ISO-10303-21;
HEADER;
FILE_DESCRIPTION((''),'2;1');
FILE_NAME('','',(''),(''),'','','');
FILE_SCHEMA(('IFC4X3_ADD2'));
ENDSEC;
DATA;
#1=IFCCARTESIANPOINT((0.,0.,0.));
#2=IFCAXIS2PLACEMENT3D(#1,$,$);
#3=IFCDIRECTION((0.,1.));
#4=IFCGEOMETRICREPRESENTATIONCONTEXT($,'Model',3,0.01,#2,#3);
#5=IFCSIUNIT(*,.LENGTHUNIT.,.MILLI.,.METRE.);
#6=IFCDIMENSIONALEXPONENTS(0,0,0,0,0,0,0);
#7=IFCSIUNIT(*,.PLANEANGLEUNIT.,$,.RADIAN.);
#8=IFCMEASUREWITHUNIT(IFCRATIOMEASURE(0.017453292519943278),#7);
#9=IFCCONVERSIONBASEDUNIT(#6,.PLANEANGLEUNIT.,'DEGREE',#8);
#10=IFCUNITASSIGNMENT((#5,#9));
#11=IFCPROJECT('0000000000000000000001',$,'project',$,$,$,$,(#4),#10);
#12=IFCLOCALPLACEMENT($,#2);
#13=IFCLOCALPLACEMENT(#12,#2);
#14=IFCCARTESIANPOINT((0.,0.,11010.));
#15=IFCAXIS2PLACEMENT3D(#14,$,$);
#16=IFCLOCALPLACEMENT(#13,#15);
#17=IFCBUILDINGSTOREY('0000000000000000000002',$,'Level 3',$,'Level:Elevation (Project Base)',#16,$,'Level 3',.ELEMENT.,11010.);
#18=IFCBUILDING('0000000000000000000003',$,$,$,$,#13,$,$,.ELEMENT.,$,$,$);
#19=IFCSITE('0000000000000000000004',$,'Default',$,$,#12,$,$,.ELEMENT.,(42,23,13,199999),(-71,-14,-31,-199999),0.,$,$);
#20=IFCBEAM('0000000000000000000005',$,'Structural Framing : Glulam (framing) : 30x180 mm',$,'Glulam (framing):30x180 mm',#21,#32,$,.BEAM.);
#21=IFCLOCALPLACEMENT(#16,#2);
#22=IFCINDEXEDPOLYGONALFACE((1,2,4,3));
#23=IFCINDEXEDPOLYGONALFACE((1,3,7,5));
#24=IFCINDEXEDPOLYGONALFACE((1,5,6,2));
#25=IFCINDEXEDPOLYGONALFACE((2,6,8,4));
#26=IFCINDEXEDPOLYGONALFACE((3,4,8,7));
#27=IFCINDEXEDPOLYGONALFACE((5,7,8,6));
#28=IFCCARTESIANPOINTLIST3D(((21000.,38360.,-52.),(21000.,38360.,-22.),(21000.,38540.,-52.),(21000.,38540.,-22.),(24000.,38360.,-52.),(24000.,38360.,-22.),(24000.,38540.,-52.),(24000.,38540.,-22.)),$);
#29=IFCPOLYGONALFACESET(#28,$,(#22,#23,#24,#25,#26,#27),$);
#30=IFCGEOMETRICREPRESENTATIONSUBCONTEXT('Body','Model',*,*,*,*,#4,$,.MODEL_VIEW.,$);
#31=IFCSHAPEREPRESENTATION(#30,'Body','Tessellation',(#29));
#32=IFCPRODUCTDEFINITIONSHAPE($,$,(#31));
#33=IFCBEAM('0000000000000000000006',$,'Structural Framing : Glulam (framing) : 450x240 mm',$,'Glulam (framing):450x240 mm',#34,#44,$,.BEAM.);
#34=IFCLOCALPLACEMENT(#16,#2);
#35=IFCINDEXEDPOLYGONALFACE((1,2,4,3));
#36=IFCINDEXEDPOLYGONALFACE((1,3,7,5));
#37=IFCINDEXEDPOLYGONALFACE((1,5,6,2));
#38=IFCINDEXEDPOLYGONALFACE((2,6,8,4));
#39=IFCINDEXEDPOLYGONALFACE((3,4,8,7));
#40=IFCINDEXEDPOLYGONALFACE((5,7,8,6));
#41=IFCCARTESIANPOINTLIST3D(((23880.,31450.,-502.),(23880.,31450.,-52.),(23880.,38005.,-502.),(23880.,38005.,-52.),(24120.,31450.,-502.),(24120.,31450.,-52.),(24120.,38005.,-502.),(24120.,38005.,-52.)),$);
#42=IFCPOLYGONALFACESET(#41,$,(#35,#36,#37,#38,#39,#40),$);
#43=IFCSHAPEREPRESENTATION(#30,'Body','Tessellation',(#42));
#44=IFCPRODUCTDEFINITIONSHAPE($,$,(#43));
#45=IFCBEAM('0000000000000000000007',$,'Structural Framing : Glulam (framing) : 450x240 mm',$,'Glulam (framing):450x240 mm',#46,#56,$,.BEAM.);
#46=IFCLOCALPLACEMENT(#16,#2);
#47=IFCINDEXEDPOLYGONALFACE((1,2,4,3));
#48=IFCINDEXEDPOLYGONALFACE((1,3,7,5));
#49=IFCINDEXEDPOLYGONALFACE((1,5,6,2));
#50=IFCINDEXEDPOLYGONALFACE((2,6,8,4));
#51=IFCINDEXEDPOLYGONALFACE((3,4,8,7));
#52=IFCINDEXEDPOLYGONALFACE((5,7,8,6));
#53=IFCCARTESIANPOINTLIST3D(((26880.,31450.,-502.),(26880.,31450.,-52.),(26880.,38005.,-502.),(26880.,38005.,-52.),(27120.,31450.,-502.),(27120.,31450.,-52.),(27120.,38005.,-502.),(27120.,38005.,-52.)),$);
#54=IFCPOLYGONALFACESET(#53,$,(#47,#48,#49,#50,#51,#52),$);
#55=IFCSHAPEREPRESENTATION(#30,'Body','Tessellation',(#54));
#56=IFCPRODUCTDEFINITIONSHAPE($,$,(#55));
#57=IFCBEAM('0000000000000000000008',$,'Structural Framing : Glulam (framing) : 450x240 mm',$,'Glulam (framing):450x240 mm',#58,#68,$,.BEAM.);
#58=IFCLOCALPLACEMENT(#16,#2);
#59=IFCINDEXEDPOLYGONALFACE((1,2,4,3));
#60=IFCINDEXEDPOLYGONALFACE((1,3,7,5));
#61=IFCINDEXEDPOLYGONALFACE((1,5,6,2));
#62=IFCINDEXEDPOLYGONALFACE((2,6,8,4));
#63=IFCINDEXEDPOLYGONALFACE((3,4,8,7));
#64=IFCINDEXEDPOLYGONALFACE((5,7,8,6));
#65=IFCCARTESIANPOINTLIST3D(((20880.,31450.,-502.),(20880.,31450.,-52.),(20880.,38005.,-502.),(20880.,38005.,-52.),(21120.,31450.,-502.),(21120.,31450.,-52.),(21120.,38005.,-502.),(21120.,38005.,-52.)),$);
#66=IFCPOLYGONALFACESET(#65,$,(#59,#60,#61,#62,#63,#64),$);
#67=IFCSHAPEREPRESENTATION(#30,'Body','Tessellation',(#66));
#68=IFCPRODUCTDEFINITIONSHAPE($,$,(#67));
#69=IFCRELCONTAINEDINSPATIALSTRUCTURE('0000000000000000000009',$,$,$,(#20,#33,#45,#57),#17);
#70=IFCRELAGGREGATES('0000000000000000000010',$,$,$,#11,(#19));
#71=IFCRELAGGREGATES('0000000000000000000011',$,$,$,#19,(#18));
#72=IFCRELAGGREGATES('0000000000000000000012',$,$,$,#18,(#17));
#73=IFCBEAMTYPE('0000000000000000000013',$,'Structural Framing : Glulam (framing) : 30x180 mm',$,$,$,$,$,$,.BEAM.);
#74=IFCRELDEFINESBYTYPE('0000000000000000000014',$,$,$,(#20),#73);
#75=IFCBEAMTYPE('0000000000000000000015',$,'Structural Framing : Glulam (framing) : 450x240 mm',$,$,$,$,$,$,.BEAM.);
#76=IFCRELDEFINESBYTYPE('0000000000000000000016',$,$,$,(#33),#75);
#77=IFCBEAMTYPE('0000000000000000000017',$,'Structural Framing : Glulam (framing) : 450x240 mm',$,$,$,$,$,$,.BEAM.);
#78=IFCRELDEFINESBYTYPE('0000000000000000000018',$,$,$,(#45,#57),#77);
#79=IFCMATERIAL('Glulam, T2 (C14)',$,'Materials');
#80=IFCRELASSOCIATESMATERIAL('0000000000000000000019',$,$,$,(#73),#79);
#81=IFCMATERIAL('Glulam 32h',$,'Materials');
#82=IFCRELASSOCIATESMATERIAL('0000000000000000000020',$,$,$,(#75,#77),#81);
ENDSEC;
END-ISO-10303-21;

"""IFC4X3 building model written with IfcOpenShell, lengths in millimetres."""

from ifc_helpers import new_model, entity, si_unit, converted_unit, direction, frame, origin, origin_2d_with_axis, place, context, subcontext, project, spatial, rectangle, extrude, source, transform, mapped, material, material_profile, profile_set, type_object, type_shapes, element, save


model = new_model("IFC4X3")

# Units and contexts
model_context = context("Model", 3, precision=0.01, world=origin(), true_north=direction((0.0, 1.0)))
body_context = subcontext(model_context, "Body", "Model", "MODEL_VIEW")
ifc_project = project(units=[si_unit("LENGTHUNIT", "METRE", prefix="MILLI"), converted_unit("PLANEANGLEUNIT", "DEGREE", entity("IfcRatioMeasure", 0.017453292519943278), si_unit("PLANEANGLEUNIT", "RADIAN"), dimensions=[0, 0, 0, 0, 0, 0, 0])], contexts=[model_context])

# Site, building, storey
site_placement = place(None, origin())
site = spatial("IfcSite", under=ifc_project, at=site_placement, Name="Default", CompositionType="ELEMENT", RefLatitude=(42, 23, 13, 199999), RefLongitude=(-71, -14, -31, -199999), RefElevation=0.0)
building_placement = place(site_placement, origin())
building = spatial("IfcBuilding", under=site, at=building_placement, CompositionType="ELEMENT")
storey_placement = place(building_placement, frame((0.0, 0.0, 11010.0)))
storey = spatial("IfcBuildingStorey", under=building, at=storey_placement, Name="Level 3", ObjectType="Level:Elevation (Project Base)", LongName="Level 3", CompositionType="ELEMENT", Elevation=11010.0)

# Beams
ifc_material_1 = material(Name="Glulam, T2 (C14)", Category="Materials")
ifc_material_profile_1 = material_profile(ifc_material_1, rectangle(XDim=30.0, YDim=180.0, at=origin_2d_with_axis()), Name="30x180 mm")
ifc_profile_set_1 = profile_set([ifc_material_profile_1], Name="30x180 mm")
beam_type_1 = type_object("IfcBeamType", Name="Structural Framing : Glulam (framing) : 30x180 mm", PredefinedType="BEAM", material=ifc_profile_set_1)
shared_shape_1 = source(origin(), body_context, "Body", "SweptSolid", [
    extrude(rectangle(XDim=30.0, YDim=180.0, at=origin_2d_with_axis()), frame((481.5, 0.0, 0.0), z_axis=(1.0, 0.0, 0.0), x_axis=(0.0, 0.0, -1.0)), (0.0, 0.0, 1.0), 3000.0),
])
type_shapes(beam_type_1, [shared_shape_1])
beam_1_placement = place(storey_placement, frame((20518.5, 38450.0, -37.0)))
element("IfcBeam", 1, at=beam_1_placement, inside=storey, type_object=beam_type_1, Name="Structural Framing : Glulam (framing) : 30x180 mm", ObjectType="Glulam (framing):30x180 mm", PredefinedType="BEAM", context=body_context, shape_type="MappedRepresentation", body=[
    mapped(shared_shape_1, transform((0.0, 0.0, 0.0), scale=1.0)),
])
ifc_material_2 = material(Name="Glulam 32h", Category="Materials")
ifc_material_profile_2 = material_profile(ifc_material_2, rectangle(XDim=450.0, YDim=240.0, at=origin_2d_with_axis()), Name="450x240 mm")
ifc_profile_set_2 = profile_set([ifc_material_profile_2], Name="450x240 mm")
beam_type_2 = type_object("IfcBeamType", Name="Structural Framing : Glulam (framing) : 450x240 mm", PredefinedType="BEAM", material=ifc_profile_set_2)
shared_shape_2 = source(origin(), body_context, "Body", "SweptSolid", [
    extrude(rectangle(XDim=450.0, YDim=240.0, at=origin_2d_with_axis()), frame((-621.3, 0.0, 0.0), z_axis=(1.0, 0.0, 0.0), x_axis=(0.0, 0.0, -1.0)), (0.0, 0.0, 1.0), 6555.0),
])
type_shapes(beam_type_2, [shared_shape_2])
beam_2_placement = place(storey_placement, frame((24000.0, 37383.7, -277.0), z_axis=(0.0, 0.0, 1.0), x_axis=(0.0, -1.0, 0.0)))
element("IfcBeam", 2, at=beam_2_placement, inside=storey, type_object=beam_type_2, Name="Structural Framing : Glulam (framing) : 450x240 mm", ObjectType="Glulam (framing):450x240 mm", PredefinedType="BEAM", context=body_context, shape_type="MappedRepresentation", body=[
    mapped(shared_shape_2, transform((0.0, 0.0, 0.0), scale=1.0)),
])
beam_type_3 = type_object("IfcBeamType", Name="Structural Framing : Glulam (framing) : 450x240 mm", PredefinedType="BEAM", material=ifc_profile_set_2)
shared_shape_3 = source(origin(), body_context, "Body", "SweptSolid", [
    extrude(rectangle(XDim=450.0, YDim=240.0, at=origin_2d_with_axis()), frame((-571.2, 0.0, 0.0), z_axis=(1.0, 0.0, 0.0), x_axis=(0.0, 0.0, -1.0)), (0.0, 0.0, 1.0), 6555.0),
])
type_shapes(beam_type_3, [shared_shape_3])
for number, where, z_axis, x_axis, name in (
    (3, (27000.0, 37433.7, -277.0), (0.0, 0.0, 1.0), (0.0, -1.0, 0.0), "Structural Framing : Glulam (framing) : 450x240 mm"),
    (4, (21000.0, 37433.7, -277.0), (0.0, 0.0, 1.0), (0.0, -1.0, 0.0), "Structural Framing : Glulam (framing) : 450x240 mm"),
):
    element("IfcBeam", number, at=place(storey_placement, frame(where, z_axis=z_axis, x_axis=x_axis)), inside=storey, type_object=beam_type_3, Name=name, ObjectType="Glulam (framing):450x240 mm", PredefinedType="BEAM", context=body_context, shape_type="MappedRepresentation", body=[
        mapped(shared_shape_3, transform((0.0, 0.0, 0.0), scale=1.0)),
    ])

save(model, "model.ifc")
